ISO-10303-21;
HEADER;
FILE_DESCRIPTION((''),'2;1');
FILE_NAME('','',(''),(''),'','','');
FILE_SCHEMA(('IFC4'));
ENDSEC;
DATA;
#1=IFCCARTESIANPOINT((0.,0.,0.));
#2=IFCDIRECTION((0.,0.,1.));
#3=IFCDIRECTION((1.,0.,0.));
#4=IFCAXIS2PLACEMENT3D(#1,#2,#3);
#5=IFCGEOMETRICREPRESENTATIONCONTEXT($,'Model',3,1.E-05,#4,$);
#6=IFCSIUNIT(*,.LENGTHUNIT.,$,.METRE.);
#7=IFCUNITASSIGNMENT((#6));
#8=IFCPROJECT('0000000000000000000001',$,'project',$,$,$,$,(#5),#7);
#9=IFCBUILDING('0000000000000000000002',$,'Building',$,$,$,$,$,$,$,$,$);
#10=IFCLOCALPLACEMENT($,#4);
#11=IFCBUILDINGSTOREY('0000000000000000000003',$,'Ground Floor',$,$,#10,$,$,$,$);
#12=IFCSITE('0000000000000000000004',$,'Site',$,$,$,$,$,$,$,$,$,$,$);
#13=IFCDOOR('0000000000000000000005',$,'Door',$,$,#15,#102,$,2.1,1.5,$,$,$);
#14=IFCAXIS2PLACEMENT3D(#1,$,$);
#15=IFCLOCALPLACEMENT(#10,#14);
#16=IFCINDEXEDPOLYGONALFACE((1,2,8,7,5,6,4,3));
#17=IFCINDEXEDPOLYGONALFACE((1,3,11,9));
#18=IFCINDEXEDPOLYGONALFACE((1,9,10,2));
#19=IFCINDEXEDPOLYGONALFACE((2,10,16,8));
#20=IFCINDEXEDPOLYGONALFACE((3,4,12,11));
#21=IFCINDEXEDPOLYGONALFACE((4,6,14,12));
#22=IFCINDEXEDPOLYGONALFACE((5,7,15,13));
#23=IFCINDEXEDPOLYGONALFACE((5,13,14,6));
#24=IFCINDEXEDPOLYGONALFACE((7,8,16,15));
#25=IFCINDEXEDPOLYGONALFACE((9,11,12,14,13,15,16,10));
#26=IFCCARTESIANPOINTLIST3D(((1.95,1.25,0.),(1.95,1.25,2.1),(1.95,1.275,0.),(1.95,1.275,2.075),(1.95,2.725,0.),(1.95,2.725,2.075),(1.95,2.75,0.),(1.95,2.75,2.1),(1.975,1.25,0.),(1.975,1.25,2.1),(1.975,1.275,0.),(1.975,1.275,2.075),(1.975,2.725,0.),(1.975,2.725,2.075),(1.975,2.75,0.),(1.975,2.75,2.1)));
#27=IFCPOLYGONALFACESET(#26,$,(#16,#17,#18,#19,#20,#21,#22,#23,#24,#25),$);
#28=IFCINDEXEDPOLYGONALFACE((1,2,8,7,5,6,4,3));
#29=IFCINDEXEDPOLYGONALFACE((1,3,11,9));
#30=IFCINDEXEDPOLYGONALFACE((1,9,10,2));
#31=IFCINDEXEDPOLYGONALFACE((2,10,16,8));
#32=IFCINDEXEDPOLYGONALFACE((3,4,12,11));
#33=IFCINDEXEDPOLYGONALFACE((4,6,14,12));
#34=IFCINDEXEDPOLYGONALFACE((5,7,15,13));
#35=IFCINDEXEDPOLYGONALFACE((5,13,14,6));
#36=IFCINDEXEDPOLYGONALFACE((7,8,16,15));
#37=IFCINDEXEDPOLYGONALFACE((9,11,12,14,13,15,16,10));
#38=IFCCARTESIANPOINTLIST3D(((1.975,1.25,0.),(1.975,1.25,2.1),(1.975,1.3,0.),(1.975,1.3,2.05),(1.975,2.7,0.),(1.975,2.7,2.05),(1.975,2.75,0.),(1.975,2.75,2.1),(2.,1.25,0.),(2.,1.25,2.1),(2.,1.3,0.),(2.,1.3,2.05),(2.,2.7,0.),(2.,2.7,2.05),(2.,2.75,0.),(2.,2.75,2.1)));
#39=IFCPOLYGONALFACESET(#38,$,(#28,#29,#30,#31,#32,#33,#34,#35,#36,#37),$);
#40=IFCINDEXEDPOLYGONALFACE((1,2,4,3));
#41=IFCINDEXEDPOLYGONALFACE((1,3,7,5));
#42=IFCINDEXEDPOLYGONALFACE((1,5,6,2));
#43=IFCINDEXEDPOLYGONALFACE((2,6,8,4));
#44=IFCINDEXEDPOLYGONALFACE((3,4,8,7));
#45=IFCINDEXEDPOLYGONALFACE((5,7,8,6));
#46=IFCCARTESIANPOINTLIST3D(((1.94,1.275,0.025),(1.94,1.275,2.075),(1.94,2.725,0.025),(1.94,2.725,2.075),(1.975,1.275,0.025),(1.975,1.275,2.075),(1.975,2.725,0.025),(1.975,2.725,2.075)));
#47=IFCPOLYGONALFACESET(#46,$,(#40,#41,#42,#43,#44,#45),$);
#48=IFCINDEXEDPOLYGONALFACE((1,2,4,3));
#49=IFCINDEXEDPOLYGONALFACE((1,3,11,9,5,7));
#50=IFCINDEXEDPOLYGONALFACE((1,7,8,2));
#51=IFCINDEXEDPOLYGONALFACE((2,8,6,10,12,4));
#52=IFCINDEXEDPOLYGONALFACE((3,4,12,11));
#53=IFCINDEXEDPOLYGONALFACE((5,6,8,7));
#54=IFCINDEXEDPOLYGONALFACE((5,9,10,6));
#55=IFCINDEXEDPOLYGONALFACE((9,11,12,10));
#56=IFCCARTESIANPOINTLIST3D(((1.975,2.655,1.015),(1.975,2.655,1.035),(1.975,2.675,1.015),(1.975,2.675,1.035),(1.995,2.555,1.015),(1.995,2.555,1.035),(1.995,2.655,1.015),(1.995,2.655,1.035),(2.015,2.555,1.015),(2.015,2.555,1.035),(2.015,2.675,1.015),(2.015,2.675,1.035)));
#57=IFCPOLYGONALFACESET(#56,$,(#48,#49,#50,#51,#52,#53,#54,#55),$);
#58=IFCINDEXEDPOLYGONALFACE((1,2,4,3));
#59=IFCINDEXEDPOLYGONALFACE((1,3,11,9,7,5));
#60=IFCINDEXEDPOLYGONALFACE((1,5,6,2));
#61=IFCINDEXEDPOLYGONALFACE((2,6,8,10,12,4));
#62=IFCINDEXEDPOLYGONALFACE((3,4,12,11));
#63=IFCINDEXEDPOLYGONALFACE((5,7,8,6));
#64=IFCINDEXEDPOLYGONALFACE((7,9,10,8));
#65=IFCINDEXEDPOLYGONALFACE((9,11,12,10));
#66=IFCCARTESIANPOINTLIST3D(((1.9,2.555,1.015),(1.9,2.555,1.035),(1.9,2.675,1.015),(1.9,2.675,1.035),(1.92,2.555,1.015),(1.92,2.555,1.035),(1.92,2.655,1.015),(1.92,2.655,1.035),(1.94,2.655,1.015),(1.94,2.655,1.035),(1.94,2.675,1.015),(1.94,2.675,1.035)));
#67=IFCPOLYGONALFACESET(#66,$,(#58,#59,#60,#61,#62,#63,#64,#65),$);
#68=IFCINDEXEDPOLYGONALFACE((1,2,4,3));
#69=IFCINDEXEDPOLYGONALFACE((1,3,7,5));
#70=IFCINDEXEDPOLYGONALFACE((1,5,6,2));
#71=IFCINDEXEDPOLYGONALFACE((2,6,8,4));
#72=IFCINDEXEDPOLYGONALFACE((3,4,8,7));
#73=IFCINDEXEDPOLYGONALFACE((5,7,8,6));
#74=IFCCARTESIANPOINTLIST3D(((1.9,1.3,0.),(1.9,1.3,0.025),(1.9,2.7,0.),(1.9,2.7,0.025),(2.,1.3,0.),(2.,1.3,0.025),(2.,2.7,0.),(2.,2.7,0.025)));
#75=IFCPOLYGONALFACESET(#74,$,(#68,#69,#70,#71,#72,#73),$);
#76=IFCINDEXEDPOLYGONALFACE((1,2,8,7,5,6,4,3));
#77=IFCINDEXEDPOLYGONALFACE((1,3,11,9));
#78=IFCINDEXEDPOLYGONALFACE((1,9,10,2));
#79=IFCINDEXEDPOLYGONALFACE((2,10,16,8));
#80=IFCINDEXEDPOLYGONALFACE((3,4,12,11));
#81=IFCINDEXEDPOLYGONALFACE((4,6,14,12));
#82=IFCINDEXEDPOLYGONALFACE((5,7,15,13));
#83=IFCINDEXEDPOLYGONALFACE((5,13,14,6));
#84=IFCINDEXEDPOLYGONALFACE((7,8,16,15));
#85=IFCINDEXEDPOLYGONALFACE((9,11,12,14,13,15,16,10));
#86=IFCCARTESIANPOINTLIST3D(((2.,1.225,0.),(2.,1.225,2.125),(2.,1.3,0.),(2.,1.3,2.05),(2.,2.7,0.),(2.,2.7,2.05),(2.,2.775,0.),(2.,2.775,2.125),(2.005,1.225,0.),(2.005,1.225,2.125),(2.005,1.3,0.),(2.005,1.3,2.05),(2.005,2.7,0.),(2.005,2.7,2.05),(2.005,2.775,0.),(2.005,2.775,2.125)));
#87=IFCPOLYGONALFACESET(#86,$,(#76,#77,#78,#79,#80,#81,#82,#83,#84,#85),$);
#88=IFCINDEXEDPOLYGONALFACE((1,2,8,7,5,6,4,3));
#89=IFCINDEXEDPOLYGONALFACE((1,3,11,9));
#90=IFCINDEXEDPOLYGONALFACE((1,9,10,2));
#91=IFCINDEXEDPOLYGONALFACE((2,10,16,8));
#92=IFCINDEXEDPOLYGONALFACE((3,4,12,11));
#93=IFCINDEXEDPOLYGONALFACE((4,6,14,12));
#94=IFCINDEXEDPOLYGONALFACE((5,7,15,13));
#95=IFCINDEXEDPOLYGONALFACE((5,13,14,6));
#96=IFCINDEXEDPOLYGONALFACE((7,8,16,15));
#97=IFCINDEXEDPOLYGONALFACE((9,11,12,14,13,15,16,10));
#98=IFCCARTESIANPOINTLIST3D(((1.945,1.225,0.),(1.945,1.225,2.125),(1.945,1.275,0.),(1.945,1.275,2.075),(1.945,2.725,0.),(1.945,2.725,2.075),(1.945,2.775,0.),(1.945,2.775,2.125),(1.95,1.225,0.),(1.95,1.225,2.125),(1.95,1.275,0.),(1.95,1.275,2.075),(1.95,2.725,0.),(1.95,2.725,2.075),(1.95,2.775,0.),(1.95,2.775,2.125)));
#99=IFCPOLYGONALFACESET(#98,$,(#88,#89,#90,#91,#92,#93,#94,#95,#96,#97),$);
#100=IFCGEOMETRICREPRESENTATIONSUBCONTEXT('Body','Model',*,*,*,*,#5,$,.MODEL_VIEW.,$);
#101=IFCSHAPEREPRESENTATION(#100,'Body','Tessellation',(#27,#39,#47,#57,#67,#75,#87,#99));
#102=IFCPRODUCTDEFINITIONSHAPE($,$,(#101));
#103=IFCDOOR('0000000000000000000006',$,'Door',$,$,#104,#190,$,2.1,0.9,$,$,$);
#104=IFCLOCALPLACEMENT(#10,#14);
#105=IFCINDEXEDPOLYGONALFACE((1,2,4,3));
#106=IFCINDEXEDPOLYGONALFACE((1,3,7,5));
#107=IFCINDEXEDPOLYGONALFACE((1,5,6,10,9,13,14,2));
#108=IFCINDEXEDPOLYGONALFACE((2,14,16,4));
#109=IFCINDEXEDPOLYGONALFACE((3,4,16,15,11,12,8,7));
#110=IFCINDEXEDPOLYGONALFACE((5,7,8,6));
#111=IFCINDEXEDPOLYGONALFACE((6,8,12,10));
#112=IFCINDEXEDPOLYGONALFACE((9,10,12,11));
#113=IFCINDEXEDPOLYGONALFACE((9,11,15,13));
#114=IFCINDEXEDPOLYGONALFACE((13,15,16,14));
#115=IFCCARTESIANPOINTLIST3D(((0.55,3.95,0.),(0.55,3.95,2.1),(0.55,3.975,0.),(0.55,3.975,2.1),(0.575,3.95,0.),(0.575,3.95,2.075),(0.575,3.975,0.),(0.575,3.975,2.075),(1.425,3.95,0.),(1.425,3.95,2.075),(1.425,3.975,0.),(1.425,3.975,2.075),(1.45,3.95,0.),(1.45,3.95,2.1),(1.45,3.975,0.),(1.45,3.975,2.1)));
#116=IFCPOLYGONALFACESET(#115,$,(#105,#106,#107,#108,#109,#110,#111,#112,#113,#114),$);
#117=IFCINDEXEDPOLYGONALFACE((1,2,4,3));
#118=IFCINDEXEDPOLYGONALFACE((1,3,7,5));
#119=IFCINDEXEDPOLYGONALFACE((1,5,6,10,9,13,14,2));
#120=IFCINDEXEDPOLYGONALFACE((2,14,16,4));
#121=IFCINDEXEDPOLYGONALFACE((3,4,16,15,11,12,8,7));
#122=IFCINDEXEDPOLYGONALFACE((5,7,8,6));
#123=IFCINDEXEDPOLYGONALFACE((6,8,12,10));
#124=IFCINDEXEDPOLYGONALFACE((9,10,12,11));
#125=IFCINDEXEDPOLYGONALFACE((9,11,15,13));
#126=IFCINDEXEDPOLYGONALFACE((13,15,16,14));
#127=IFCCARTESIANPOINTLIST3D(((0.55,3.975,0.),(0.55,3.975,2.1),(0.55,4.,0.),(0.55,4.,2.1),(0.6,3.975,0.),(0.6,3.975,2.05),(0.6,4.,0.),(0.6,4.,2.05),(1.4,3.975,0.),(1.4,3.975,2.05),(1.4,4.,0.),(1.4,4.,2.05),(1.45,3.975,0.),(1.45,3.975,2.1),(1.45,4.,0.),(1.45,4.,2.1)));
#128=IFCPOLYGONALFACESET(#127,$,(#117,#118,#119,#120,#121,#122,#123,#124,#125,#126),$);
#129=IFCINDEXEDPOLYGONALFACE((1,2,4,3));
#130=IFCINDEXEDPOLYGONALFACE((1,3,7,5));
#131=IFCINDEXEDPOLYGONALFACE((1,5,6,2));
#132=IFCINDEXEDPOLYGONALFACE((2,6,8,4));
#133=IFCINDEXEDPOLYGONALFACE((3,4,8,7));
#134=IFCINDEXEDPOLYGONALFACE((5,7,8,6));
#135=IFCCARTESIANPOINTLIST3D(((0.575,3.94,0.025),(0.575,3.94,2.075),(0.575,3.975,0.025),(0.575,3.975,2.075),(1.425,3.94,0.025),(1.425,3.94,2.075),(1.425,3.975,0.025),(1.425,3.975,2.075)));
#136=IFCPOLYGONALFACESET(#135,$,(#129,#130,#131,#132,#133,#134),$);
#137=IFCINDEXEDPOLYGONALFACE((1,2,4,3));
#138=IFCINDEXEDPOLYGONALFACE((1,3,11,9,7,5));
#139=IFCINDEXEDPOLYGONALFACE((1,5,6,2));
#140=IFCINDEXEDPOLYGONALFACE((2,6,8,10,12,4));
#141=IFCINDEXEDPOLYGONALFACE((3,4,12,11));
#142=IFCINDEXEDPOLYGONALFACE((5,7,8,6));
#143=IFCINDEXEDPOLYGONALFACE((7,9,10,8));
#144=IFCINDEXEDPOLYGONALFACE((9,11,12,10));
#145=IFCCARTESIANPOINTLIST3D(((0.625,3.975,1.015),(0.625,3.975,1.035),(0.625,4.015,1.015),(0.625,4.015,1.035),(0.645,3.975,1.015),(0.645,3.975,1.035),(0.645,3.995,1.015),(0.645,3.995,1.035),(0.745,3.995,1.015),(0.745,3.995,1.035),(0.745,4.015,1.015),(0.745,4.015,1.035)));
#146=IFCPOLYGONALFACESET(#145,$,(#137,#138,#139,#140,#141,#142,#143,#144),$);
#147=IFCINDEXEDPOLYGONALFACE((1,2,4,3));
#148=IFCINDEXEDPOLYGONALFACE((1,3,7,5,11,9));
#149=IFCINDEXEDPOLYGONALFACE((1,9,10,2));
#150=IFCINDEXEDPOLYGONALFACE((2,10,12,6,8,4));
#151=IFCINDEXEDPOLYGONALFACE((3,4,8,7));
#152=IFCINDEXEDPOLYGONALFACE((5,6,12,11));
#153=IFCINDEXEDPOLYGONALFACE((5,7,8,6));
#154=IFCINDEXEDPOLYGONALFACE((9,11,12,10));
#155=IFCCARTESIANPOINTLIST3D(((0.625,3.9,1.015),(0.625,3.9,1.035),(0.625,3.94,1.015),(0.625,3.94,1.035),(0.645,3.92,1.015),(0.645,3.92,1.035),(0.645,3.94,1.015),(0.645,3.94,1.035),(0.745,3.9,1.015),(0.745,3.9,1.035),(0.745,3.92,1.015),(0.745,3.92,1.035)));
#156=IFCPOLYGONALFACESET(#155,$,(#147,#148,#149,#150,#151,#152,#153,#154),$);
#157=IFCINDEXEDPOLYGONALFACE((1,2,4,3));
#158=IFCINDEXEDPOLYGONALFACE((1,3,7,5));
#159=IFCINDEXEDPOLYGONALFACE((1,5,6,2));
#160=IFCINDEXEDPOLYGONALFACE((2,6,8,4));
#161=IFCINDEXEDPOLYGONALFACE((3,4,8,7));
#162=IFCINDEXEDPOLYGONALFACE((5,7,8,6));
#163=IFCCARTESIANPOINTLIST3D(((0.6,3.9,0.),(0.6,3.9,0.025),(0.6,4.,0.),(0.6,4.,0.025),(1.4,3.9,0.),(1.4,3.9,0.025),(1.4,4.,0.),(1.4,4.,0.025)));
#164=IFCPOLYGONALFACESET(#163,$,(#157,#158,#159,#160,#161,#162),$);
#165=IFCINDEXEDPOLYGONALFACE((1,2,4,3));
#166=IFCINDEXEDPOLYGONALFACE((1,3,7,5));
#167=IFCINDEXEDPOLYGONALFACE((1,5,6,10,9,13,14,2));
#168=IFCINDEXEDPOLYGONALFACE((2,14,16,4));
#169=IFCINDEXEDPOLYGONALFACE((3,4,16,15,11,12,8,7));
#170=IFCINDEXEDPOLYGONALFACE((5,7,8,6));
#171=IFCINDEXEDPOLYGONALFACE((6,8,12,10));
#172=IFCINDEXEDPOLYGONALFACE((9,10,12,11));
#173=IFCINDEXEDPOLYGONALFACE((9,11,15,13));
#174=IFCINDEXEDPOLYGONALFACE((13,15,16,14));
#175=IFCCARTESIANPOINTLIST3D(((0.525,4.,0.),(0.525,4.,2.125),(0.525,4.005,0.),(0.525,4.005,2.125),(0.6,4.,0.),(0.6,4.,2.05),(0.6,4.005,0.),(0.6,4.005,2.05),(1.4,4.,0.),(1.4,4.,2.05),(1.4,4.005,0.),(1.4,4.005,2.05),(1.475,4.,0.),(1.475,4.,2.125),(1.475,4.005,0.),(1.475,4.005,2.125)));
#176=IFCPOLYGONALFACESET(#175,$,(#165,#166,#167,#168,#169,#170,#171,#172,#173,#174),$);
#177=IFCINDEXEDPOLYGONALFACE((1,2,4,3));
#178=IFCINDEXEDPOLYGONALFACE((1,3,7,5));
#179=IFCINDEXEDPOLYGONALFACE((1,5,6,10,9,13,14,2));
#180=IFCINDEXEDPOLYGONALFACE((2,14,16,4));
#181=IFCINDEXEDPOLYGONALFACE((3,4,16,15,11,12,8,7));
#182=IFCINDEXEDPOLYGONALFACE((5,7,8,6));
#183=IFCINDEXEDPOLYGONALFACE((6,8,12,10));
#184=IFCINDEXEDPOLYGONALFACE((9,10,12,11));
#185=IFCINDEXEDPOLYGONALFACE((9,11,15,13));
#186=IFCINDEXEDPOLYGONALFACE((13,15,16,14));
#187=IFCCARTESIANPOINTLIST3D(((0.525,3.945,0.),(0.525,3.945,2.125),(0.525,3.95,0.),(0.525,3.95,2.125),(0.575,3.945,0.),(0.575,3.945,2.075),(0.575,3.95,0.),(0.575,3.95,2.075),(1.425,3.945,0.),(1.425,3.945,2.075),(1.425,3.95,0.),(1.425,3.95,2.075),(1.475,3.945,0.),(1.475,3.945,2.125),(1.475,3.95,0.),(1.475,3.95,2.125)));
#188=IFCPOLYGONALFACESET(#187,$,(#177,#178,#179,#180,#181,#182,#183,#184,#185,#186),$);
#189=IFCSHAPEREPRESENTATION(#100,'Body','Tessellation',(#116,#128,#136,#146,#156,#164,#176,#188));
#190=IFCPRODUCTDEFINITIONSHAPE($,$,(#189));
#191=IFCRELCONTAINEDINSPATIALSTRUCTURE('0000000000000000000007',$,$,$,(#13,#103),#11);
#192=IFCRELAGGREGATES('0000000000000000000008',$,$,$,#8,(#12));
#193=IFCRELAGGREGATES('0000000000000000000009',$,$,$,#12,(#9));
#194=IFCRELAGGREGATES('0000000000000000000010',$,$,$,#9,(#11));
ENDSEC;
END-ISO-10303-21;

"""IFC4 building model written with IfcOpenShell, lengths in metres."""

from ifc_helpers import new_model, si_unit, frame, origin_with_axes, place, context, subcontext, project, spatial, line, indexed_curve, outline, extrude, element, save


model = new_model("IFC4")

# Units and contexts
model_context = context("Model", 3, precision=1e-05, world=origin_with_axes())
body_context = subcontext(model_context, "Body", "Model", "MODEL_VIEW")
ifc_project = project(units=[si_unit("LENGTHUNIT", "METRE")], contexts=[model_context])

# Site, building, storey
site = spatial("IfcSite", under=ifc_project, Name="Site")
building = spatial("IfcBuilding", under=site, Name="Building")
storey_placement = place(None, origin_with_axes())
storey = spatial("IfcBuildingStorey", under=building, at=storey_placement, Name="Ground Floor")

# Doors
door_1_placement = place(storey_placement, frame((2.0, 1.25, 0.0), z_axis=(0.0, 0.0, 1.0), x_axis=(0.0, 1.0, 0.0)))
element("IfcDoor", 1, at=door_1_placement, inside=storey, Name="Door", OverallHeight=2.1, OverallWidth=1.5, context=body_context, shape_type="SweptSolid", body=[
    extrude(outline(indexed_curve([(0.0, 0.0), (0.0, 2.1), (1.5, 2.1), (1.5, 0.0), (1.475, 0.0), (1.475, 2.075), (0.025, 2.075), (0.025, 0.0)], segments=[line(1, 2, 3, 4, 5, 6, 7, 8, 1)])), frame((0.0, 0.025, 0.0), z_axis=(0.0, -1.0, 0.0), x_axis=(1.0, 0.0, 0.0)), (0.0, 0.0, -1.0), 0.025),
    extrude(outline(indexed_curve([(0.0, 0.0), (0.0, 2.1), (1.5, 2.1), (1.5, 0.0), (1.45, 0.0), (1.45, 2.05), (0.05, 2.05), (0.05, 0.0)], segments=[line(1, 2, 3, 4, 5, 6, 7, 8, 1)])), frame((0.0, 0.0, 0.0), z_axis=(0.0, -1.0, 0.0), x_axis=(1.0, 0.0, 0.0)), (0.0, 0.0, -1.0), 0.025),
    extrude(outline(indexed_curve([(0.0, 0.0), (1.45, 0.0), (1.45, 0.035), (0.0, 0.035)], segments=[line(1, 2, 3, 4, 1)])), frame((0.025, 0.025, 0.025), z_axis=(0.0, 0.0, 1.0), x_axis=(1.0, 0.0, 0.0)), (0.0, 0.0, 1.0), 2.05),
    extrude(outline(indexed_curve([(0.0, 0.0), (0.0, -0.04), (-0.12, -0.04), (-0.12, -0.02), (-0.02, -0.02), (-0.02, 0.0)], segments=[line(1, 2, 3, 4, 5, 6, 1)])), frame((1.425, 0.025, 1.015), z_axis=(0.0, 0.0, 1.0), x_axis=(1.0, 0.0, 0.0)), (0.0, 0.0, 1.0), 0.02),
    extrude(outline(indexed_curve([(0.0, 0.0), (0.0, 0.04), (-0.12, 0.04), (-0.12, 0.02), (-0.02, 0.02), (-0.02, 0.0)], segments=[line(1, 2, 3, 4, 5, 6, 1)])), frame((1.425, 0.06, 1.015), z_axis=(0.0, 0.0, 1.0), x_axis=(1.0, 0.0, 0.0)), (0.0, 0.0, 1.0), 0.02),
    extrude(outline(indexed_curve([(0.0, 0.0), (1.4, 0.0), (1.4, 0.1), (0.0, 0.1)], segments=[line(1, 2, 3, 4, 1)])), frame((0.05, 0.0, 0.0), z_axis=(0.0, 0.0, 1.0), x_axis=(1.0, 0.0, 0.0)), (0.0, 0.0, 1.0), 0.025),
    extrude(outline(indexed_curve([(0.0, 0.0), (0.0, 2.125), (1.55, 2.125), (1.55, 0.0), (1.475, 0.0), (1.475, 2.05), (0.075, 2.05), (0.075, 0.0)], segments=[line(1, 2, 3, 4, 5, 6, 7, 8, 1)])), frame((-0.025, -0.005, 0.0), z_axis=(0.0, -1.0, 0.0), x_axis=(1.0, 0.0, 0.0)), (0.0, 0.0, -1.0), 0.005),
    extrude(outline(indexed_curve([(0.0, 0.0), (0.0, 2.125), (1.55, 2.125), (1.55, 0.0), (1.5, 0.0), (1.5, 2.075), (0.05, 2.075), (0.05, 0.0)], segments=[line(1, 2, 3, 4, 5, 6, 7, 8, 1)])), frame((-0.025, 0.05, 0.0), z_axis=(0.0, -1.0, 0.0), x_axis=(1.0, 0.0, 0.0)), (0.0, 0.0, -1.0), 0.005),
])
door_2_placement = place(storey_placement, frame((1.45, 4.0, 0.0), z_axis=(0.0, 0.0, 1.0), x_axis=(-1.0, 0.0, 0.0)))
element("IfcDoor", 2, at=door_2_placement, inside=storey, Name="Door", OverallHeight=2.1, OverallWidth=0.9, context=body_context, shape_type="SweptSolid", body=[
    extrude(outline(indexed_curve([(0.0, 0.0), (0.0, 2.1), (0.9, 2.1), (0.9, 0.0), (0.875, 0.0), (0.875, 2.075), (0.025, 2.075), (0.025, 0.0)], segments=[line(1, 2, 3, 4, 5, 6, 7, 8, 1)])), frame((0.0, 0.025, 0.0), z_axis=(0.0, -1.0, 0.0), x_axis=(1.0, 0.0, 0.0)), (0.0, 0.0, -1.0), 0.025),
    extrude(outline(indexed_curve([(0.0, 0.0), (0.0, 2.1), (0.9, 2.1), (0.9, 0.0), (0.85, 0.0), (0.85, 2.05), (0.05, 2.05), (0.05, 0.0)], segments=[line(1, 2, 3, 4, 5, 6, 7, 8, 1)])), frame((0.0, 0.0, 0.0), z_axis=(0.0, -1.0, 0.0), x_axis=(1.0, 0.0, 0.0)), (0.0, 0.0, -1.0), 0.025),
    extrude(outline(indexed_curve([(0.0, 0.0), (0.85, 0.0), (0.85, 0.035), (0.0, 0.035)], segments=[line(1, 2, 3, 4, 1)])), frame((0.025, 0.025, 0.025), z_axis=(0.0, 0.0, 1.0), x_axis=(1.0, 0.0, 0.0)), (0.0, 0.0, 1.0), 2.05),
    extrude(outline(indexed_curve([(0.0, 0.0), (0.0, -0.04), (-0.12, -0.04), (-0.12, -0.02), (-0.02, -0.02), (-0.02, 0.0)], segments=[line(1, 2, 3, 4, 5, 6, 1)])), frame((0.825, 0.025, 1.015), z_axis=(0.0, 0.0, 1.0), x_axis=(1.0, 0.0, 0.0)), (0.0, 0.0, 1.0), 0.02),
    extrude(outline(indexed_curve([(0.0, 0.0), (0.0, 0.04), (-0.12, 0.04), (-0.12, 0.02), (-0.02, 0.02), (-0.02, 0.0)], segments=[line(1, 2, 3, 4, 5, 6, 1)])), frame((0.825, 0.06, 1.015), z_axis=(0.0, 0.0, 1.0), x_axis=(1.0, 0.0, 0.0)), (0.0, 0.0, 1.0), 0.02),
    extrude(outline(indexed_curve([(0.0, 0.0), (0.8, 0.0), (0.8, 0.1), (0.0, 0.1)], segments=[line(1, 2, 3, 4, 1)])), frame((0.05, 0.0, 0.0), z_axis=(0.0, 0.0, 1.0), x_axis=(1.0, 0.0, 0.0)), (0.0, 0.0, 1.0), 0.025),
    extrude(outline(indexed_curve([(0.0, 0.0), (0.0, 2.125), (0.95, 2.125), (0.95, 0.0), (0.875, 0.0), (0.875, 2.05), (0.075, 2.05), (0.075, 0.0)], segments=[line(1, 2, 3, 4, 5, 6, 7, 8, 1)])), frame((-0.025, -0.005, 0.0), z_axis=(0.0, -1.0, 0.0), x_axis=(1.0, 0.0, 0.0)), (0.0, 0.0, -1.0), 0.005),
    extrude(outline(indexed_curve([(0.0, 0.0), (0.0, 2.125), (0.95, 2.125), (0.95, 0.0), (0.9, 0.0), (0.9, 2.075), (0.05, 2.075), (0.05, 0.0)], segments=[line(1, 2, 3, 4, 5, 6, 7, 8, 1)])), frame((-0.025, 0.05, 0.0), z_axis=(0.0, -1.0, 0.0), x_axis=(1.0, 0.0, 0.0)), (0.0, 0.0, -1.0), 0.005),
])

save(model, "model.ifc")
